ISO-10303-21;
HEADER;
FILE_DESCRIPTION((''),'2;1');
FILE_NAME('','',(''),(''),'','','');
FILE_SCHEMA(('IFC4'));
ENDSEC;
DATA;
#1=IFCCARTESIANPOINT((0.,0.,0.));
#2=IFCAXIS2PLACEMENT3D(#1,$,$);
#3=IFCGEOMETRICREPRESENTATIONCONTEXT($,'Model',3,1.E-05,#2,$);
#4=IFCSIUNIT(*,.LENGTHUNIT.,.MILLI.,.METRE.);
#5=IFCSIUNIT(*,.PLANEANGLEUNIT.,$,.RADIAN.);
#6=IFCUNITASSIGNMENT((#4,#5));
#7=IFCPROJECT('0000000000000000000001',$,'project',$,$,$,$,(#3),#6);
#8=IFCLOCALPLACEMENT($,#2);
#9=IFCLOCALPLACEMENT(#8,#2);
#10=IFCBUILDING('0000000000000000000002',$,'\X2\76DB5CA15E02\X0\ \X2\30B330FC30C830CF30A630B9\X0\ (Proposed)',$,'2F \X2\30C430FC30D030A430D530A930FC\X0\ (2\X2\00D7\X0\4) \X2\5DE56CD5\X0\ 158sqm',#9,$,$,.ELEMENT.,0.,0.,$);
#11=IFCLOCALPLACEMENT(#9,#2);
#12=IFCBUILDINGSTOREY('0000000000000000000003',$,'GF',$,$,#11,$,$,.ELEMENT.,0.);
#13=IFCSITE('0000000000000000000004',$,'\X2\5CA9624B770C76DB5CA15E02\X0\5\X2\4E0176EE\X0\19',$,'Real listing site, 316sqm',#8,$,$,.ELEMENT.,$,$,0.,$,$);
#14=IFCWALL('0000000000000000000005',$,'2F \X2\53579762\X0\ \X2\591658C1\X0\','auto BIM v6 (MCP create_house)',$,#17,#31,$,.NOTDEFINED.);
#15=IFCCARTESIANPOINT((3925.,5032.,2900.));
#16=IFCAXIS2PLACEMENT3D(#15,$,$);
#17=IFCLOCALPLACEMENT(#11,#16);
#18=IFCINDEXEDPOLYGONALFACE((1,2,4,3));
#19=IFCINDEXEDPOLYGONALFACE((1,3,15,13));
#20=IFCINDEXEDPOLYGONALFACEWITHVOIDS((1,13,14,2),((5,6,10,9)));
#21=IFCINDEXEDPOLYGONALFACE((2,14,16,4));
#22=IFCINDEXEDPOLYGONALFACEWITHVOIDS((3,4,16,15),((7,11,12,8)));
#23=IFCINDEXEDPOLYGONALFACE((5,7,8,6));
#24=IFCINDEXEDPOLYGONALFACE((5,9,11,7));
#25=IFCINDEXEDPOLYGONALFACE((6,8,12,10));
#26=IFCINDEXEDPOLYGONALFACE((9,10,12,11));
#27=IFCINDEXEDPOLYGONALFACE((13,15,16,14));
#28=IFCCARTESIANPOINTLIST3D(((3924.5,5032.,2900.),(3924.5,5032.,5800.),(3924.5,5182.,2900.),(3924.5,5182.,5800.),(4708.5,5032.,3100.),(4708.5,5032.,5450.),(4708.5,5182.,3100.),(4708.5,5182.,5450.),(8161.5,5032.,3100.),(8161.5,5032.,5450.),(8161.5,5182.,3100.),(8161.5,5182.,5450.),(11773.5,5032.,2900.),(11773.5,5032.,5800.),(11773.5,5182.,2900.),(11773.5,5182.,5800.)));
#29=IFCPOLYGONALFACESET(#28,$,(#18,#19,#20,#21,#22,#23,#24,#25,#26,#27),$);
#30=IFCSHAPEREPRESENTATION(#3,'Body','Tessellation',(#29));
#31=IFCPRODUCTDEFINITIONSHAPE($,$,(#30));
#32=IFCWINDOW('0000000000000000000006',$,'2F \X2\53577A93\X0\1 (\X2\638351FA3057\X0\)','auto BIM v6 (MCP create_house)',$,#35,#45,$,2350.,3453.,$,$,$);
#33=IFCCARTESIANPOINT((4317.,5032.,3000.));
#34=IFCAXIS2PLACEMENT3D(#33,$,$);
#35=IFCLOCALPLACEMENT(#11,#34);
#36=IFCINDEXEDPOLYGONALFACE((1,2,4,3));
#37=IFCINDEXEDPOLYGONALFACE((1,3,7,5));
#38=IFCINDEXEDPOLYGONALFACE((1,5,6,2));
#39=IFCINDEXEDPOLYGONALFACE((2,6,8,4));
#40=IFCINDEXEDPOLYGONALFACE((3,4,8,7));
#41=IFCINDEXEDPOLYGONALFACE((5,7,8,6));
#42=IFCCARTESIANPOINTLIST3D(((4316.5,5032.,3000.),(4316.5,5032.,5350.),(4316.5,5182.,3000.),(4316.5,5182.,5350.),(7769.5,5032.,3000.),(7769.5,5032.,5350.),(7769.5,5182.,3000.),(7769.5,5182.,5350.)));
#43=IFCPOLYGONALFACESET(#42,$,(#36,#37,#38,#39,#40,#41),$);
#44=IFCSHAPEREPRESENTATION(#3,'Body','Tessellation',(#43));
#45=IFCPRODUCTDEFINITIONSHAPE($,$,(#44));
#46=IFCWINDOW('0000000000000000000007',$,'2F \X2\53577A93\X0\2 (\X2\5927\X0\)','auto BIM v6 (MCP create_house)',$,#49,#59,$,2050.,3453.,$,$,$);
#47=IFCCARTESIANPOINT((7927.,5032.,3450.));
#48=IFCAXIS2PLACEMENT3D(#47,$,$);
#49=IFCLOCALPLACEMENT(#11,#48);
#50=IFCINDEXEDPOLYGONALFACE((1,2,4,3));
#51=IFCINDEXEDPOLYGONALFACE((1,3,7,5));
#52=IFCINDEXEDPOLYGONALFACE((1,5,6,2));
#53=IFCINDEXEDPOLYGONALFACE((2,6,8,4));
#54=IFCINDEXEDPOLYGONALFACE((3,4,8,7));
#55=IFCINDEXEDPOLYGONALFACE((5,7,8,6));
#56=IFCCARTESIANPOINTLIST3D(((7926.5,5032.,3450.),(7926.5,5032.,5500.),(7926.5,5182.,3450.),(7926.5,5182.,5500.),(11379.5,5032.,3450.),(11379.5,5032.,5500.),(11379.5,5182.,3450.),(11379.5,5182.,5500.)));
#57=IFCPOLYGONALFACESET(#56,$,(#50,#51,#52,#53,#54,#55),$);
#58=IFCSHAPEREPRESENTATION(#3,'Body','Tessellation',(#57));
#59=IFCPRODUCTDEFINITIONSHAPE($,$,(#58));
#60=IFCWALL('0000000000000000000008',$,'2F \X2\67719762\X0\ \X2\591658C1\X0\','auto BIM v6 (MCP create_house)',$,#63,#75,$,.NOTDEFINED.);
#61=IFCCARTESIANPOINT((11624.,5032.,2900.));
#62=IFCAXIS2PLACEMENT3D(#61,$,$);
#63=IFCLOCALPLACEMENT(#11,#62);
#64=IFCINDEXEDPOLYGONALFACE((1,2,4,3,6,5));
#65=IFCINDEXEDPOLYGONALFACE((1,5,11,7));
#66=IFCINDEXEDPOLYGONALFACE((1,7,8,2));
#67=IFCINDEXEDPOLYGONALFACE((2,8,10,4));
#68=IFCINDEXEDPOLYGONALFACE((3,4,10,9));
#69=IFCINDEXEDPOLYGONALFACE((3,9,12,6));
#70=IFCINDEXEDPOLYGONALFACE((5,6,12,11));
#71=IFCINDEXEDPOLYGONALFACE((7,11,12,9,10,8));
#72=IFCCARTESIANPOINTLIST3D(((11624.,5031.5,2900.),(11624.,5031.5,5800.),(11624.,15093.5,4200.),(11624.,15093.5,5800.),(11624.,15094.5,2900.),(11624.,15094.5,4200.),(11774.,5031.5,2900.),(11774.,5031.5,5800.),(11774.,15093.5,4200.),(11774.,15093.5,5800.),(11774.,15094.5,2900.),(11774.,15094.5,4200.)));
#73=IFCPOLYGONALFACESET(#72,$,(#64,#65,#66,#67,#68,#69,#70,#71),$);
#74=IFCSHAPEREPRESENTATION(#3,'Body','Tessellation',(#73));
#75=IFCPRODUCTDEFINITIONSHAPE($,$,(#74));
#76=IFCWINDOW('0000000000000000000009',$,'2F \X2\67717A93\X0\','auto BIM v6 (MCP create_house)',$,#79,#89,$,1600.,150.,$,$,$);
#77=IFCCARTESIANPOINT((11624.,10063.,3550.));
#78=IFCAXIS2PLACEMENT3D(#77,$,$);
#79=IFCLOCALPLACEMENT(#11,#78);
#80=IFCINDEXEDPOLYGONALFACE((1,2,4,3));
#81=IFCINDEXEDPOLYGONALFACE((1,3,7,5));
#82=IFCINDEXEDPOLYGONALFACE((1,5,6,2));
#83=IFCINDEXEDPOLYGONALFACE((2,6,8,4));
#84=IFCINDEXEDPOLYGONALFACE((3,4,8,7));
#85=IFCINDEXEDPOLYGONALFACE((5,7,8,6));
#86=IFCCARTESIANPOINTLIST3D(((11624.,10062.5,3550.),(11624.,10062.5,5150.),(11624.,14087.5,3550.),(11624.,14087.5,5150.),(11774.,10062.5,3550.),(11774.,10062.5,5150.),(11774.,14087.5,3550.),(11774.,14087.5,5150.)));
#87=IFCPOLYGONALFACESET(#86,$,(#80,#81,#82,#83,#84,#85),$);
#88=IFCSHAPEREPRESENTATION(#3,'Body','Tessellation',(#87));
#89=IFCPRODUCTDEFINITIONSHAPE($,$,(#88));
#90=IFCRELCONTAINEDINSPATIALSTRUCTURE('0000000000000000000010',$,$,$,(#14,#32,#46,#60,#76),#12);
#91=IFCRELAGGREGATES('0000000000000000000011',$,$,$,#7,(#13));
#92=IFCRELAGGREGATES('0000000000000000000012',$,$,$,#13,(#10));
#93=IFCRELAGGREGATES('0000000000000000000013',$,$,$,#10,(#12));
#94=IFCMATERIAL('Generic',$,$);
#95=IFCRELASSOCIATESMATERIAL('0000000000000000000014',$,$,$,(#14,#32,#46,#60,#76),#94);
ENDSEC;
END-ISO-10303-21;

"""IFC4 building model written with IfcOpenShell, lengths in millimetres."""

from ifc_helpers import new_model, si_unit, frame, frame_2d, origin, place, context, project, spatial, rectangle, extrude, material, element, fill, save


model = new_model("IFC4")

# Units and contexts
model_context = context("Model", 3, precision=1e-05, world=origin())
ifc_project = project(units=[si_unit("LENGTHUNIT", "METRE", prefix="MILLI"), si_unit("PLANEANGLEUNIT", "RADIAN")], contexts=[model_context])

# Site, building, storey
site_placement = place(None, origin())
site = spatial("IfcSite", under=ifc_project, at=site_placement, Name="岩手県盛岡市5丁目19", ObjectType="Real listing site, 316sqm", CompositionType="ELEMENT", RefElevation=0.0)
building_placement = place(site_placement, origin())
building = spatial("IfcBuilding", under=site, at=building_placement, Name="盛岡市 コートハウス (Proposed)", ObjectType="2F ツーバイフォー (2×4) 工法 158sqm", CompositionType="ELEMENT", ElevationOfRefHeight=0.0, ElevationOfTerrain=0.0)
storey_placement = place(building_placement, origin())
storey = spatial("IfcBuildingStorey", under=building, at=storey_placement, Name="GF", CompositionType="ELEMENT", Elevation=0.0)

# Shared definitions
ifc_material = material(Name="Generic")

# Wall, openings, windows
wall_1_placement = place(storey_placement, frame((3925.0, 5032.0, 2900.0)))
wall_1 = element("IfcWall", 1, at=wall_1_placement, inside=storey, material=ifc_material, Name="2F 南面 外壁", Description="auto BIM v6 (MCP create_house)", PredefinedType="NOTDEFINED", context=model_context, shape_type="SweptSolid", body=[
    extrude(rectangle(XDim=7849.0, YDim=150.0, at=frame_2d((3924.0, 75.0))), frame((3925.0, 5032.0, 2900.0)), (0.0, 0.0, 1.0), 2900.0),
])
opening_1_placement = place(storey_placement, frame((4317.0, 5032.0, 3000.0)))
opening_1 = element("IfcOpeningElement", 2, at=opening_1_placement, cuts=wall_1, PredefinedType="NOTDEFINED", context=model_context, shape_type="SweptSolid", body=[
    extrude(rectangle(XDim=3453.0, YDim=150.0, at=frame_2d((1726.0, 75.0))), frame((4317.0, 5032.0, 3000.0)), (0.0, 0.0, 1.0), 2350.0),
])
opening_2_placement = place(storey_placement, frame((7927.0, 5032.0, 3450.0)))
opening_2 = element("IfcOpeningElement", 3, at=opening_2_placement, cuts=wall_1, PredefinedType="NOTDEFINED", context=model_context, shape_type="SweptSolid", body=[
    extrude(rectangle(XDim=3453.0, YDim=150.0, at=frame_2d((1726.0, 75.0))), frame((7927.0, 5032.0, 3450.0)), (0.0, 0.0, 1.0), 2050.0),
])
window_1_placement = place(storey_placement, frame((4317.0, 5032.0, 3000.0)))
window_1 = element("IfcWindow", 4, at=window_1_placement, inside=storey, material=ifc_material, Name="2F 南窓1 (掃出し)", Description="auto BIM v6 (MCP create_house)", OverallHeight=2350.0, OverallWidth=3453.0, context=model_context, shape_type="SweptSolid", body=[
    extrude(rectangle(XDim=3453.0, YDim=150.0, at=frame_2d((1726.0, 75.0))), frame((4317.0, 5032.0, 3000.0)), (0.0, 0.0, 1.0), 2350.0),
])
fill(opening_1, window_1)
window_2_placement = place(storey_placement, frame((7927.0, 5032.0, 3450.0)))
window_2 = element("IfcWindow", 5, at=window_2_placement, inside=storey, material=ifc_material, Name="2F 南窓2 (大)", Description="auto BIM v6 (MCP create_house)", OverallHeight=2050.0, OverallWidth=3453.0, context=model_context, shape_type="SweptSolid", body=[
    extrude(rectangle(XDim=3453.0, YDim=150.0, at=frame_2d((1726.0, 75.0))), frame((7927.0, 5032.0, 3450.0)), (0.0, 0.0, 1.0), 2050.0),
])
fill(opening_2, window_2)

# Wall, opening, window
wall_2_placement = place(storey_placement, frame((11624.0, 5032.0, 2900.0)))
wall_2 = element("IfcWall", 6, at=wall_2_placement, inside=storey, material=ifc_material, Name="2F 東面 外壁", Description="auto BIM v6 (MCP create_house)", PredefinedType="NOTDEFINED", context=model_context, shape_type="SweptSolid", body=[
    extrude(rectangle(XDim=150.0, YDim=10063.0, at=frame_2d((75.0, 5031.0))), frame((11624.0, 5032.0, 2900.0)), (0.0, 0.0, 1.0), 2900.0),
])
opening_3_placement = place(storey_placement, frame((11624.0, 10063.0, 3550.0)))
opening_3 = element("IfcOpeningElement", 7, at=opening_3_placement, cuts=wall_2, PredefinedType="NOTDEFINED", context=model_context, shape_type="SweptSolid", body=[
    extrude(rectangle(XDim=150.0, YDim=4025.0, at=frame_2d((75.0, 2012.0))), frame((11624.0, 10063.0, 3550.0)), (0.0, 0.0, 1.0), 1600.0),
])
window_3_placement = place(storey_placement, frame((11624.0, 10063.0, 3550.0)))
window_3 = element("IfcWindow", 8, at=window_3_placement, inside=storey, material=ifc_material, Name="2F 東窓", Description="auto BIM v6 (MCP create_house)", OverallHeight=1600.0, OverallWidth=150.0, context=model_context, shape_type="SweptSolid", body=[
    extrude(rectangle(XDim=150.0, YDim=4025.0, at=frame_2d((75.0, 2012.0))), frame((11624.0, 10063.0, 3550.0)), (0.0, 0.0, 1.0), 1600.0),
])
fill(opening_3, window_3)

save(model, "model.ifc")
